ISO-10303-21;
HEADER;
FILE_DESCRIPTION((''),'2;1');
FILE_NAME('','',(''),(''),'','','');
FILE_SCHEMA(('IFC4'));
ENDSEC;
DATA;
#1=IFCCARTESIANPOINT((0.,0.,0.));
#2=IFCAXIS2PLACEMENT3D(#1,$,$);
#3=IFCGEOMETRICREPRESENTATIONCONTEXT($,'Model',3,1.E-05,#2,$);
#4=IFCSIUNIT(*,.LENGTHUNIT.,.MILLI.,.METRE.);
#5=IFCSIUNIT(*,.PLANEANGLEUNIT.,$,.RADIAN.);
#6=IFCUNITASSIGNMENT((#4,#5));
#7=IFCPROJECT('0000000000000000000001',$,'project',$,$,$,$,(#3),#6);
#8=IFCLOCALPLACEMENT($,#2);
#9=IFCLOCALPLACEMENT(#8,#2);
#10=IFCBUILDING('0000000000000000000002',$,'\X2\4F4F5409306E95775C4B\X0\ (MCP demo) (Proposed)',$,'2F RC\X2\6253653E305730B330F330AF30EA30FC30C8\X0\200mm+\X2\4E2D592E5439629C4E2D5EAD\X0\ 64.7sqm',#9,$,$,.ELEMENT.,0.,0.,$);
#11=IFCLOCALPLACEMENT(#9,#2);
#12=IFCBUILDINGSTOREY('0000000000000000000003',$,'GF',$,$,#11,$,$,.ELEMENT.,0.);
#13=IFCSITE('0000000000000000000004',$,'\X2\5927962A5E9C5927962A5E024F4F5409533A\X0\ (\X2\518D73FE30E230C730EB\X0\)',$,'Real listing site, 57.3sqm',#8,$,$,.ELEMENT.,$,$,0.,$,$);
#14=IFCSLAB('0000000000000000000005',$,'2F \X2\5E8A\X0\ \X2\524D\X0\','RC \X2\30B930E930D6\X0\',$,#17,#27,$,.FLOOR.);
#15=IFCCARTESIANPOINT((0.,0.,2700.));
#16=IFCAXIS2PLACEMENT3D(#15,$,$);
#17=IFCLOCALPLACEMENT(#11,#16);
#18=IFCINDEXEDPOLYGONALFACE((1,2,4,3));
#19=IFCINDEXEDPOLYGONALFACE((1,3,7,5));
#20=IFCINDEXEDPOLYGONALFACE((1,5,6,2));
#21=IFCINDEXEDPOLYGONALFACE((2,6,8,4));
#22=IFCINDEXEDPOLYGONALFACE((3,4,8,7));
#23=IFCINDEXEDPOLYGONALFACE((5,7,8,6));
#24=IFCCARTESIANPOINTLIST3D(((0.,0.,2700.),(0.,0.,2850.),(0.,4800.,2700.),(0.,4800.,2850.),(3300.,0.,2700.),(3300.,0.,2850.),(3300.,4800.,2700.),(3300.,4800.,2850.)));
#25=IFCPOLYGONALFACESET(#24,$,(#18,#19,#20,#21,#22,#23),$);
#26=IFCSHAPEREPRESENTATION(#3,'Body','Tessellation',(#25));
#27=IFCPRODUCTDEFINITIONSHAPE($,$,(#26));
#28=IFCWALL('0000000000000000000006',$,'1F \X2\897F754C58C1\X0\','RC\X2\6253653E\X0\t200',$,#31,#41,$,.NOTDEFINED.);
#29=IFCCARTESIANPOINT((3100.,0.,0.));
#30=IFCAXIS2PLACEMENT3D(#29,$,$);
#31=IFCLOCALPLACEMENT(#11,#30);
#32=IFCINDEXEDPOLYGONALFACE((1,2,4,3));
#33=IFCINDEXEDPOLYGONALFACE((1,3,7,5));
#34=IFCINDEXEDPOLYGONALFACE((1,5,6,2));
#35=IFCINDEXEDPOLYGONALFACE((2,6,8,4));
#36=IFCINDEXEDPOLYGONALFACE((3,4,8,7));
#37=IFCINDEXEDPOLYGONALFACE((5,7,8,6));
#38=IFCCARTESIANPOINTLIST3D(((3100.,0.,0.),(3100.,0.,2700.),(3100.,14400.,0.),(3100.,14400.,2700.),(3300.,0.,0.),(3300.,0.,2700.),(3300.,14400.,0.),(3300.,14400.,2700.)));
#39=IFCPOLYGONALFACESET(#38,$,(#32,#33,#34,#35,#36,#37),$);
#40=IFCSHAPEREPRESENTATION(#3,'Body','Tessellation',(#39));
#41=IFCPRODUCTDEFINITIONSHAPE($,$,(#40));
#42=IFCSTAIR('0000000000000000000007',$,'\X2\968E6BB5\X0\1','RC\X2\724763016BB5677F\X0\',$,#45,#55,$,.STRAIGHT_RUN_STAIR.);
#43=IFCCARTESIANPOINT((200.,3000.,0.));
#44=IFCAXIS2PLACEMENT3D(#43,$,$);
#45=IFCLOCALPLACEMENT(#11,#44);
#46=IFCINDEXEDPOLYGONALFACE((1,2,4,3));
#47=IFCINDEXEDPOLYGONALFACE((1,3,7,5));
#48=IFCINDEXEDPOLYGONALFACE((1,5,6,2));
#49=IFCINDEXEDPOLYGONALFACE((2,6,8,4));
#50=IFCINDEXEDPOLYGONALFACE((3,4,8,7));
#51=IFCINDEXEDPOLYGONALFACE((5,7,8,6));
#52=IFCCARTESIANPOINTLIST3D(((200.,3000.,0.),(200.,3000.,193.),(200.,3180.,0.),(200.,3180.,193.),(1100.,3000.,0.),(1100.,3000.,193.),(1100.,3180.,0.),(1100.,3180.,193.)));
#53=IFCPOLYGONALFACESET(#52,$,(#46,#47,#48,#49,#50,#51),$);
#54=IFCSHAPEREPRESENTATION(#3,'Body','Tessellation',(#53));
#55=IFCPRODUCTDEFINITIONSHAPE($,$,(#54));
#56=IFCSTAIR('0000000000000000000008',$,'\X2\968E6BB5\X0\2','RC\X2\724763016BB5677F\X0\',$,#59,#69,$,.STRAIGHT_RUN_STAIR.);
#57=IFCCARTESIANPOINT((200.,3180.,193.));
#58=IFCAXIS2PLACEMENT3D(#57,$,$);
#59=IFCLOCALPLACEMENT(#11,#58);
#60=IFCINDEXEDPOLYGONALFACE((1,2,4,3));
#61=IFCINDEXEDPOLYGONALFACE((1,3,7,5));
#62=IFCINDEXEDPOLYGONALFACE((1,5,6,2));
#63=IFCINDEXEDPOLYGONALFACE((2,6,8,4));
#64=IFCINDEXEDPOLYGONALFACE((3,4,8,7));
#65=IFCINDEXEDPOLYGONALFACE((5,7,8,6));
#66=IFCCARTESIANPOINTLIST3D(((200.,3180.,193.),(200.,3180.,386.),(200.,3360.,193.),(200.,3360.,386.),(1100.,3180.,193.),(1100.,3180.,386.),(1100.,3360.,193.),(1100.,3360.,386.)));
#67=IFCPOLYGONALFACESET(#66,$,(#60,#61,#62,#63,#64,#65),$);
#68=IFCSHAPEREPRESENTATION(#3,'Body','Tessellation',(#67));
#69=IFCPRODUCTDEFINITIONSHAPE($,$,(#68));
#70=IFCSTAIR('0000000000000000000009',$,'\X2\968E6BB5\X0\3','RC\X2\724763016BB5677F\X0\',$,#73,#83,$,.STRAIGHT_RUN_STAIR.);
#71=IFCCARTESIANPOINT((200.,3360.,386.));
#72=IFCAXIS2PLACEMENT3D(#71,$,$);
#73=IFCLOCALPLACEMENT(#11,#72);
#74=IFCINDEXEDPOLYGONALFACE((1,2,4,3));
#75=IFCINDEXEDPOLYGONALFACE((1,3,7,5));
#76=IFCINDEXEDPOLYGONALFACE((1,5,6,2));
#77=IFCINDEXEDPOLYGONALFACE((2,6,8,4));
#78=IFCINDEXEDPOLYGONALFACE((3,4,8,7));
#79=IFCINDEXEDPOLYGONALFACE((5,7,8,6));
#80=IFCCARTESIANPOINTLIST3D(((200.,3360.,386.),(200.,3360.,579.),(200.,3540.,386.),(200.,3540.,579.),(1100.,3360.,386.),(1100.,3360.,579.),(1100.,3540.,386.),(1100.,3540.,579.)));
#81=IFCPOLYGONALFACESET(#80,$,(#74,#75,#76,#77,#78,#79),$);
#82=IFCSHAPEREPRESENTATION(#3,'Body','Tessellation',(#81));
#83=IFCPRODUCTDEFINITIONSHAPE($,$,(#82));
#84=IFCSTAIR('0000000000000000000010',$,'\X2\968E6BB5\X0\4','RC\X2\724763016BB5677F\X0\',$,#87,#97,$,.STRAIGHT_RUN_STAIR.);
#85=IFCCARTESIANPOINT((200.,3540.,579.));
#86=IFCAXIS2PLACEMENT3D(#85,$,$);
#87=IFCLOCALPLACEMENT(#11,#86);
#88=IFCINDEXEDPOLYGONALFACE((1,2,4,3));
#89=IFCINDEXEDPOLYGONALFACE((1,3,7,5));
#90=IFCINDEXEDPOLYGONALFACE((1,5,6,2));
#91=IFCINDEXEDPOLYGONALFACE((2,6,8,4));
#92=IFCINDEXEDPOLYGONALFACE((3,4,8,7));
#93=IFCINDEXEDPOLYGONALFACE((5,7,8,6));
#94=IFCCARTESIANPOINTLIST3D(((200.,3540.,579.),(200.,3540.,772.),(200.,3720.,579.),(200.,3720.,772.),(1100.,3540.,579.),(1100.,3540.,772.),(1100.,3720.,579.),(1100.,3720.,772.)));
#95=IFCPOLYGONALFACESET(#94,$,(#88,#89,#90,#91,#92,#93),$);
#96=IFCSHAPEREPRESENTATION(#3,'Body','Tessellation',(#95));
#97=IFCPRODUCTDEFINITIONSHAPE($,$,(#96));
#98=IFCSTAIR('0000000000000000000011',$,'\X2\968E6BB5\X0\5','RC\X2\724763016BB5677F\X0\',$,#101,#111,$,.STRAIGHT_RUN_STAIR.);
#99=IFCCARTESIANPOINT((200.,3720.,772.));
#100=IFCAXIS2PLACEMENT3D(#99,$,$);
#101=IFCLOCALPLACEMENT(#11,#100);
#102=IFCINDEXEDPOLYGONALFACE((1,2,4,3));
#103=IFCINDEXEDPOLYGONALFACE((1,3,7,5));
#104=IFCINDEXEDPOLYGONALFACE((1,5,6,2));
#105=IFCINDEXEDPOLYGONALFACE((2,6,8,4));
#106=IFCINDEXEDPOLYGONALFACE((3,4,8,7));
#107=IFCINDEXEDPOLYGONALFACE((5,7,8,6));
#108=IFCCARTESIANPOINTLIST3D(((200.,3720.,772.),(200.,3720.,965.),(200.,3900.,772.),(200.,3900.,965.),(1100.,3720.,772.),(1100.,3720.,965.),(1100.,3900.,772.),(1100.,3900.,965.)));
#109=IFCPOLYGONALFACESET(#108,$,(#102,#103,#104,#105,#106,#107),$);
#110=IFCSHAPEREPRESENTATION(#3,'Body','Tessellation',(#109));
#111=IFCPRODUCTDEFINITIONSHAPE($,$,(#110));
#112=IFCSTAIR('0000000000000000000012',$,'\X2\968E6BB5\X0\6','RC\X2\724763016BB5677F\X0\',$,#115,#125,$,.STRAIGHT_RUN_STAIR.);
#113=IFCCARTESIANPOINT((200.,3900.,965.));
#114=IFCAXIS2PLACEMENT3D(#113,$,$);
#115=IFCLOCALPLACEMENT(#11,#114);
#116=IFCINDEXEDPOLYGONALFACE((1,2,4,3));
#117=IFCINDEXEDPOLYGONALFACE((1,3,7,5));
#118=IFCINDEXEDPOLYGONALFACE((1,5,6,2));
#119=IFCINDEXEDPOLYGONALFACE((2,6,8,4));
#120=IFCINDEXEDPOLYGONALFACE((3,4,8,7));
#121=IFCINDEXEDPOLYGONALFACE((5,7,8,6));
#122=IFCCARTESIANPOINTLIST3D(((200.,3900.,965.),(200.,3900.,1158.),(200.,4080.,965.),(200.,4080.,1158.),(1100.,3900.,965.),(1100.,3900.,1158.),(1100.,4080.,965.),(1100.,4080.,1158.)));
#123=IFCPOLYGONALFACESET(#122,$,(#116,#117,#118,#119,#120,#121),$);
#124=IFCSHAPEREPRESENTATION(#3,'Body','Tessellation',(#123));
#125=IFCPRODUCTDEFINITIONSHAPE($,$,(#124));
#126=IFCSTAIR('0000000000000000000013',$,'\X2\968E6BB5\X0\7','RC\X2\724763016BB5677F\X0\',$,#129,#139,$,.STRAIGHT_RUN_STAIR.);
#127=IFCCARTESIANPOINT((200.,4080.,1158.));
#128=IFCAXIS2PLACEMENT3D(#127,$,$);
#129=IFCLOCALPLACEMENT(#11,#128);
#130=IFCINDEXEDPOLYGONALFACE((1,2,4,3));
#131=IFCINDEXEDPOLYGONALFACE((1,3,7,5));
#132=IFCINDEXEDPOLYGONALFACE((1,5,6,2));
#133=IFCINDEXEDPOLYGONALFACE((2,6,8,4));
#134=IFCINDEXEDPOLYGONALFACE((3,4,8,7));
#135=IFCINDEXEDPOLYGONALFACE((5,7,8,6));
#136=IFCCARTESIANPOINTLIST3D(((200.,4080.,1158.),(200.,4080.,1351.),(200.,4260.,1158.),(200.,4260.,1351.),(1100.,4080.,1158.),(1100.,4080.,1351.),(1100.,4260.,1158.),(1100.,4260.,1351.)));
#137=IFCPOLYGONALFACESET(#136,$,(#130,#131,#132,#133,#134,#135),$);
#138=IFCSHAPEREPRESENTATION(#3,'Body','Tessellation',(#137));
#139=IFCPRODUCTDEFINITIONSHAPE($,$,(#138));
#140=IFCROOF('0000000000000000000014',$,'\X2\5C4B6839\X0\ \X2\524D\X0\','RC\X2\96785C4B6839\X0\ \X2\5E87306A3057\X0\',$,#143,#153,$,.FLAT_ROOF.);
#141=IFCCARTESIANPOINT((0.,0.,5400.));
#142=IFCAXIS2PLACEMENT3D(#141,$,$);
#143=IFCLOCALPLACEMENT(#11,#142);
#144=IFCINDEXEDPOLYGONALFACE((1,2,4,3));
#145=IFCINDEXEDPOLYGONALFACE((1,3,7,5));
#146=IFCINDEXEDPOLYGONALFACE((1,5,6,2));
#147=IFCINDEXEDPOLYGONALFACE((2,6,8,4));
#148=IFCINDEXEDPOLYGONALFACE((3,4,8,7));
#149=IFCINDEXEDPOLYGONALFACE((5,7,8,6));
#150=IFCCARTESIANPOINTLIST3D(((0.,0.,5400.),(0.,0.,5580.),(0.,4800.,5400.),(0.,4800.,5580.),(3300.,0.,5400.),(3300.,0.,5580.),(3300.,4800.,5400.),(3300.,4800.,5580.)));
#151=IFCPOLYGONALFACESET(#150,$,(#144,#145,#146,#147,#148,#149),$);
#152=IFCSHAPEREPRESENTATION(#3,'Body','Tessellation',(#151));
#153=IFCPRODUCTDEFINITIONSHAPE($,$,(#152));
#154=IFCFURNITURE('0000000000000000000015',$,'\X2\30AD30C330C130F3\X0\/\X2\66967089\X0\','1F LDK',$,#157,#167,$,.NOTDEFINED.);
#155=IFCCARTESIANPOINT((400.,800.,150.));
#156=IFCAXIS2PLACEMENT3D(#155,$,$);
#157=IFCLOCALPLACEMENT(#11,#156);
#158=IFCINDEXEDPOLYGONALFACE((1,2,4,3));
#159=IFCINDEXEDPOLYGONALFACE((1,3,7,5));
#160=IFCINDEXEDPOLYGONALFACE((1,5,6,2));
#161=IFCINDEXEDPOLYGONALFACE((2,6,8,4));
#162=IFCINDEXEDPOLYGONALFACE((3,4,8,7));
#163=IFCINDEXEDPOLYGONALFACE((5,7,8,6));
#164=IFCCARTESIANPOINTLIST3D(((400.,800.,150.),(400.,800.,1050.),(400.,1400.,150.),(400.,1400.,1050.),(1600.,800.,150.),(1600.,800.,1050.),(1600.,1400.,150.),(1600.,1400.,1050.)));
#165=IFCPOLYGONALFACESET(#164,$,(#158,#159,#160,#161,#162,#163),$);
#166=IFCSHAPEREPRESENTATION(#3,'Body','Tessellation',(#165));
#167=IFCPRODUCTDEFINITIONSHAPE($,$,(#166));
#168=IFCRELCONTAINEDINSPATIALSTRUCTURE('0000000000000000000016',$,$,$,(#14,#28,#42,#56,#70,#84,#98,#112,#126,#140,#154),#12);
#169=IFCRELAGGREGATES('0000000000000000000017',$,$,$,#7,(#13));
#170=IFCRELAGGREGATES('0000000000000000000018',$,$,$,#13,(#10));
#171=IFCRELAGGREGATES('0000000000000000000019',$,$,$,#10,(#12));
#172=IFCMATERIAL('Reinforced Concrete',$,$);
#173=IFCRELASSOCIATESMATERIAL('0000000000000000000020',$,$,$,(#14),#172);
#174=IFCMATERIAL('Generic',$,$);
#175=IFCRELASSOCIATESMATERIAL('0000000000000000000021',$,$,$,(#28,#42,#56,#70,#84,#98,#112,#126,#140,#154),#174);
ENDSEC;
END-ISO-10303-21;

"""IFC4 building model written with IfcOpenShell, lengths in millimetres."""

from ifc_helpers import new_model, si_unit, frame, frame_2d, origin, place, context, project, spatial, rectangle, extrude, material, element, save


model = new_model("IFC4")

# Units and contexts
model_context = context("Model", 3, precision=1e-05, world=origin())
ifc_project = project(units=[si_unit("LENGTHUNIT", "METRE", prefix="MILLI"), si_unit("PLANEANGLEUNIT", "RADIAN")], contexts=[model_context])

# Site, building, storey
site_placement = place(None, origin())
site = spatial("IfcSite", under=ifc_project, at=site_placement, Name="大阪府大阪市住吉区 (再現モデル)", ObjectType="Real listing site, 57.3sqm", CompositionType="ELEMENT", RefElevation=0.0)
building_placement = place(site_placement, origin())
building = spatial("IfcBuilding", under=site, at=building_placement, Name="住吉の長屋 (MCP demo) (Proposed)", ObjectType="2F RC打放しコンクリート200mm+中央吹抜中庭 64.7sqm", CompositionType="ELEMENT", ElevationOfRefHeight=0.0, ElevationOfTerrain=0.0)
storey_placement = place(building_placement, origin())
storey = spatial("IfcBuildingStorey", under=building, at=storey_placement, Name="GF", CompositionType="ELEMENT", Elevation=0.0)

# Slab
ifc_material_1 = material(Name="Reinforced Concrete")
slab_1_placement = place(storey_placement, frame((0.0, 0.0, 2700.0)))
element("IfcSlab", 1, at=slab_1_placement, inside=storey, material=ifc_material_1, Name="2F 床 前", Description="RC スラブ", PredefinedType="FLOOR", context=model_context, shape_type="SweptSolid", body=[
    extrude(rectangle(XDim=3300.0, YDim=4800.0, at=frame_2d((1650.0, 2400.0))), frame((0.0, 0.0, 2700.0)), (0.0, 0.0, 1.0), 150.0),
])

# Wall
ifc_material_2 = material(Name="Generic")
wall_1_placement = place(storey_placement, frame((3100.0, 0.0, 0.0)))
element("IfcWall", 2, at=wall_1_placement, inside=storey, material=ifc_material_2, Name="1F 西界壁", Description="RC打放t200", PredefinedType="NOTDEFINED", context=model_context, shape_type="SweptSolid", body=[
    extrude(rectangle(XDim=200.0, YDim=14400.0, at=frame_2d((100.0, 7200.0))), frame((3100.0, 0.0, 0.0)), (0.0, 0.0, 1.0), 2700.0),
])

# Stairs
stair_1_placement = place(storey_placement, frame((200.0, 3000.0, 0.0)))
element("IfcStair", 3, at=stair_1_placement, inside=storey, material=ifc_material_2, Name="階段1", Description="RC片持段板", PredefinedType="STRAIGHT_RUN_STAIR", context=model_context, shape_type="SweptSolid", body=[
    extrude(rectangle(XDim=900.0, YDim=180.0, at=frame_2d((450.0, 90.0))), frame((200.0, 3000.0, 0.0)), (0.0, 0.0, 1.0), 193.0),
])
stair_2_placement = place(storey_placement, frame((200.0, 3180.0, 193.0)))
element("IfcStair", 4, at=stair_2_placement, inside=storey, material=ifc_material_2, Name="階段2", Description="RC片持段板", PredefinedType="STRAIGHT_RUN_STAIR", context=model_context, shape_type="SweptSolid", body=[
    extrude(rectangle(XDim=900.0, YDim=180.0, at=frame_2d((450.0, 90.0))), frame((200.0, 3180.0, 193.0)), (0.0, 0.0, 1.0), 193.0),
])
stair_3_placement = place(storey_placement, frame((200.0, 3360.0, 386.0)))
element("IfcStair", 5, at=stair_3_placement, inside=storey, material=ifc_material_2, Name="階段3", Description="RC片持段板", PredefinedType="STRAIGHT_RUN_STAIR", context=model_context, shape_type="SweptSolid", body=[
    extrude(rectangle(XDim=900.0, YDim=180.0, at=frame_2d((450.0, 90.0))), frame((200.0, 3360.0, 386.0)), (0.0, 0.0, 1.0), 193.0),
])
stair_4_placement = place(storey_placement, frame((200.0, 3540.0, 579.0)))
element("IfcStair", 6, at=stair_4_placement, inside=storey, material=ifc_material_2, Name="階段4", Description="RC片持段板", PredefinedType="STRAIGHT_RUN_STAIR", context=model_context, shape_type="SweptSolid", body=[
    extrude(rectangle(XDim=900.0, YDim=180.0, at=frame_2d((450.0, 90.0))), frame((200.0, 3540.0, 579.0)), (0.0, 0.0, 1.0), 193.0),
])
stair_5_placement = place(storey_placement, frame((200.0, 3720.0, 772.0)))
element("IfcStair", 7, at=stair_5_placement, inside=storey, material=ifc_material_2, Name="階段5", Description="RC片持段板", PredefinedType="STRAIGHT_RUN_STAIR", context=model_context, shape_type="SweptSolid", body=[
    extrude(rectangle(XDim=900.0, YDim=180.0, at=frame_2d((450.0, 90.0))), frame((200.0, 3720.0, 772.0)), (0.0, 0.0, 1.0), 193.0),
])
stair_6_placement = place(storey_placement, frame((200.0, 3900.0, 965.0)))
element("IfcStair", 8, at=stair_6_placement, inside=storey, material=ifc_material_2, Name="階段6", Description="RC片持段板", PredefinedType="STRAIGHT_RUN_STAIR", context=model_context, shape_type="SweptSolid", body=[
    extrude(rectangle(XDim=900.0, YDim=180.0, at=frame_2d((450.0, 90.0))), frame((200.0, 3900.0, 965.0)), (0.0, 0.0, 1.0), 193.0),
])
stair_7_placement = place(storey_placement, frame((200.0, 4080.0, 1158.0)))
element("IfcStair", 9, at=stair_7_placement, inside=storey, material=ifc_material_2, Name="階段7", Description="RC片持段板", PredefinedType="STRAIGHT_RUN_STAIR", context=model_context, shape_type="SweptSolid", body=[
    extrude(rectangle(XDim=900.0, YDim=180.0, at=frame_2d((450.0, 90.0))), frame((200.0, 4080.0, 1158.0)), (0.0, 0.0, 1.0), 193.0),
])

# Roof
roof_placement = place(storey_placement, frame((0.0, 0.0, 5400.0)))
element("IfcRoof", 10, at=roof_placement, inside=storey, material=ifc_material_2, Name="屋根 前", Description="RC陸屋根 庇なし", PredefinedType="FLAT_ROOF", context=model_context, shape_type="SweptSolid", body=[
    extrude(rectangle(XDim=3300.0, YDim=4800.0, at=frame_2d((1650.0, 2400.0))), frame((0.0, 0.0, 5400.0)), (0.0, 0.0, 1.0), 180.0),
])

# Furniture
furniture_1_placement = place(storey_placement, frame((400.0, 800.0, 150.0)))
element("IfcFurniture", 11, at=furniture_1_placement, inside=storey, material=ifc_material_2, Name="キッチン/暖炉", Description="1F LDK", PredefinedType="NOTDEFINED", context=model_context, shape_type="SweptSolid", body=[
    extrude(rectangle(XDim=1200.0, YDim=600.0, at=frame_2d((600.0, 300.0))), frame((400.0, 800.0, 150.0)), (0.0, 0.0, 1.0), 900.0),
])

save(model, "model.ifc")
